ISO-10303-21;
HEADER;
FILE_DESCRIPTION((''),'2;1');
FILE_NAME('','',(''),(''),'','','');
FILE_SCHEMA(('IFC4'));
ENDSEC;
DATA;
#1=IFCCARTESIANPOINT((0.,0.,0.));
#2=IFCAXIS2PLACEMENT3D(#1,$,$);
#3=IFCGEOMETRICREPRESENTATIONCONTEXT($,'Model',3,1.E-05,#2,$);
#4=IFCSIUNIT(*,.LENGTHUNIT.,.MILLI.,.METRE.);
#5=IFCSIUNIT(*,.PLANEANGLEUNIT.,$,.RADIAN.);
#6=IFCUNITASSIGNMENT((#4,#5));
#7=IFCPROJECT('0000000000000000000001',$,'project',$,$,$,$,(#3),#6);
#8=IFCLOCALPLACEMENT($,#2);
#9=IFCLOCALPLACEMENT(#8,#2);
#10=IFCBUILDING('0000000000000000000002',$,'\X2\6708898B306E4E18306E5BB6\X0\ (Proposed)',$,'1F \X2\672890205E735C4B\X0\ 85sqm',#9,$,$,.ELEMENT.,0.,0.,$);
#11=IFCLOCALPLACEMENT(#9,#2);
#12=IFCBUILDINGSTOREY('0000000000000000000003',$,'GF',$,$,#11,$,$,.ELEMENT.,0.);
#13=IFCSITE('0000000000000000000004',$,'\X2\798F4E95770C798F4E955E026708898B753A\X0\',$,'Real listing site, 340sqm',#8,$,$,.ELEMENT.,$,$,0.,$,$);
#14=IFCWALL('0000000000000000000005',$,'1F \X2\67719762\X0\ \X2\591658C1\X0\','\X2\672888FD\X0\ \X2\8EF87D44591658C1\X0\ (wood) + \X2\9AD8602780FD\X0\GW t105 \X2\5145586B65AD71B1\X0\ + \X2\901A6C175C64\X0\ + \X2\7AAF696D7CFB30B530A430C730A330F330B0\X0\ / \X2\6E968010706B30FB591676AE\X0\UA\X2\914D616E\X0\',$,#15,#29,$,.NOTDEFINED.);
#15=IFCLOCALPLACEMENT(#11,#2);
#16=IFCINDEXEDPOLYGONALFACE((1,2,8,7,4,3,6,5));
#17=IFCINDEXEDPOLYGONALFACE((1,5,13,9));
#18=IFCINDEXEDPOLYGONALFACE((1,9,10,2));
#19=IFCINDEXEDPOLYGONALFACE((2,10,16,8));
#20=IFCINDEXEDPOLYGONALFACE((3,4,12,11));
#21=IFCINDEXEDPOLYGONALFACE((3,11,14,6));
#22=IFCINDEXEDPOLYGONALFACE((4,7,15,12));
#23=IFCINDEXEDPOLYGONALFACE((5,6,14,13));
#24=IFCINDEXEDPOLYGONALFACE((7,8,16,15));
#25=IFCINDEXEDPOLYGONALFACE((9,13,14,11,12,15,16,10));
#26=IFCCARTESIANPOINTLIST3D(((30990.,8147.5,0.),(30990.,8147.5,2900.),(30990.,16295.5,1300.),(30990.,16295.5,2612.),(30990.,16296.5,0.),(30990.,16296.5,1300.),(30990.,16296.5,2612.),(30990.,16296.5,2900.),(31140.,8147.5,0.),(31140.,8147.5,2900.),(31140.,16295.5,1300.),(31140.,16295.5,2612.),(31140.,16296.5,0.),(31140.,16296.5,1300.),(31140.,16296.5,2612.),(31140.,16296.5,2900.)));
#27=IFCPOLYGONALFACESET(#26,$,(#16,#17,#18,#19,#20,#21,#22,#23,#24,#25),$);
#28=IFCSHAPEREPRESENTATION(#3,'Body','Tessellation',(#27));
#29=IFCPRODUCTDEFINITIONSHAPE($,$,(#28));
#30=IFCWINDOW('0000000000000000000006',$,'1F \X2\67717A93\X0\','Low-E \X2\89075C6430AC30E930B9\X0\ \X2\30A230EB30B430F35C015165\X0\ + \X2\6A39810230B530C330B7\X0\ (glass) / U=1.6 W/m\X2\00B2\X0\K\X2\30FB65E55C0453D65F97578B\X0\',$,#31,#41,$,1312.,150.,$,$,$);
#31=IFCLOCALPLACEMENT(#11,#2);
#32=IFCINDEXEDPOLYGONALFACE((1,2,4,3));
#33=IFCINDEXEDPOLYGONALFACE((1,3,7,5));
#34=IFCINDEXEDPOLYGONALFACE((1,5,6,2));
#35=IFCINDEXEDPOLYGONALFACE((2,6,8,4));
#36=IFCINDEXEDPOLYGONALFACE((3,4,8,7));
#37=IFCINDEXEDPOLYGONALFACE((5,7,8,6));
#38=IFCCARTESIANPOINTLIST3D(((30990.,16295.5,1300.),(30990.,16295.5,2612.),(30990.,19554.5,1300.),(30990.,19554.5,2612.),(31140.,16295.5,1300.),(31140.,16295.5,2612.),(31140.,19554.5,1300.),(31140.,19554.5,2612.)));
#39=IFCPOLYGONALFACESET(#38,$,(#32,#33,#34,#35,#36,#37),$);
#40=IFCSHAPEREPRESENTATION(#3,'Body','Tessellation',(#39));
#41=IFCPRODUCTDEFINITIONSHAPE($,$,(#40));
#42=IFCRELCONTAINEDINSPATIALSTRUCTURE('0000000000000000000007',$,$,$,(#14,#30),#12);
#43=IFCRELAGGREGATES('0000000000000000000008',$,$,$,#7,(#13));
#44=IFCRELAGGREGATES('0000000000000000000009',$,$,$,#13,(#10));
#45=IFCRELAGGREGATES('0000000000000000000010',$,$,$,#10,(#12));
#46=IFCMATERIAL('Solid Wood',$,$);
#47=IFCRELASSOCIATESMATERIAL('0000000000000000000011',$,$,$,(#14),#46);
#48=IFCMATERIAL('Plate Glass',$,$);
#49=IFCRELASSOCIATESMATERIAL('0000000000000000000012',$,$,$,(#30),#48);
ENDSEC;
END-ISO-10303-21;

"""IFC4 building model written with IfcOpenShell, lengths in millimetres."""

from ifc_helpers import new_model, si_unit, frame, frame_2d, origin, place, context, project, spatial, rectangle, extrude, material, element, fill, save


model = new_model("IFC4")

# Units and contexts
model_context = context("Model", 3, precision=1e-05, world=origin())
ifc_project = project(units=[si_unit("LENGTHUNIT", "METRE", prefix="MILLI"), si_unit("PLANEANGLEUNIT", "RADIAN")], contexts=[model_context])

# Site, building, storey
site_placement = place(None, origin())
site = spatial("IfcSite", under=ifc_project, at=site_placement, Name="福井県福井市月見町", ObjectType="Real listing site, 340sqm", CompositionType="ELEMENT", RefElevation=0.0)
building_placement = place(site_placement, origin())
building = spatial("IfcBuilding", under=site, at=building_placement, Name="月見の丘の家 (Proposed)", ObjectType="1F 木造平屋 85sqm", CompositionType="ELEMENT", ElevationOfRefHeight=0.0, ElevationOfTerrain=0.0)
storey_placement = place(building_placement, origin())
storey = spatial("IfcBuildingStorey", under=building, at=storey_placement, Name="GF", CompositionType="ELEMENT", Elevation=0.0)

# Wall, opening, window
ifc_material_1 = material(Name="Solid Wood")
wall_1_placement = place(storey_placement, frame((15495.0, 4074.0, 0.0)))
wall_1 = element("IfcWall", 1, at=wall_1_placement, inside=storey, material=ifc_material_1, Name="1F 東面 外壁", Description="木製 軸組外壁 (wood) + 高性能GW t105 充填断熱 + 通気層 + 窯業系サイディング / 準耐火・外皮UA配慮", PredefinedType="NOTDEFINED", context=model_context, shape_type="SweptSolid", body=[
    extrude(rectangle(XDim=150.0, YDim=8149.0, at=frame_2d((75.0, 4074.0))), frame((15495.0, 4074.0, 0.0)), (0.0, 0.0, 1.0), 2900.0),
])
opening_1_placement = place(storey_placement, frame((15495.0, 8148.0, 650.0)))
opening_1 = element("IfcOpeningElement", 2, at=opening_1_placement, cuts=wall_1, PredefinedType="NOTDEFINED", context=model_context, shape_type="SweptSolid", body=[
    extrude(rectangle(XDim=150.0, YDim=3259.0, at=frame_2d((75.0, 1629.0))), frame((15495.0, 8148.0, 650.0)), (0.0, 0.0, 1.0), 1312.0),
])
ifc_material_2 = material(Name="Plate Glass")
window_1_placement = place(storey_placement, frame((15495.0, 8148.0, 650.0)))
window_1 = element("IfcWindow", 3, at=window_1_placement, inside=storey, material=ifc_material_2, Name="1F 東窓", Description="Low-E 複層ガラス アルゴン封入 + 樹脂サッシ (glass) / U=1.6 W/m²K・日射取得型", OverallHeight=1312.0, OverallWidth=150.0, context=model_context, shape_type="SweptSolid", body=[
    extrude(rectangle(XDim=150.0, YDim=3259.0, at=frame_2d((75.0, 1629.0))), frame((15495.0, 8148.0, 650.0)), (0.0, 0.0, 1.0), 1312.0),
])
fill(opening_1, window_1)

save(model, "model.ifc")
